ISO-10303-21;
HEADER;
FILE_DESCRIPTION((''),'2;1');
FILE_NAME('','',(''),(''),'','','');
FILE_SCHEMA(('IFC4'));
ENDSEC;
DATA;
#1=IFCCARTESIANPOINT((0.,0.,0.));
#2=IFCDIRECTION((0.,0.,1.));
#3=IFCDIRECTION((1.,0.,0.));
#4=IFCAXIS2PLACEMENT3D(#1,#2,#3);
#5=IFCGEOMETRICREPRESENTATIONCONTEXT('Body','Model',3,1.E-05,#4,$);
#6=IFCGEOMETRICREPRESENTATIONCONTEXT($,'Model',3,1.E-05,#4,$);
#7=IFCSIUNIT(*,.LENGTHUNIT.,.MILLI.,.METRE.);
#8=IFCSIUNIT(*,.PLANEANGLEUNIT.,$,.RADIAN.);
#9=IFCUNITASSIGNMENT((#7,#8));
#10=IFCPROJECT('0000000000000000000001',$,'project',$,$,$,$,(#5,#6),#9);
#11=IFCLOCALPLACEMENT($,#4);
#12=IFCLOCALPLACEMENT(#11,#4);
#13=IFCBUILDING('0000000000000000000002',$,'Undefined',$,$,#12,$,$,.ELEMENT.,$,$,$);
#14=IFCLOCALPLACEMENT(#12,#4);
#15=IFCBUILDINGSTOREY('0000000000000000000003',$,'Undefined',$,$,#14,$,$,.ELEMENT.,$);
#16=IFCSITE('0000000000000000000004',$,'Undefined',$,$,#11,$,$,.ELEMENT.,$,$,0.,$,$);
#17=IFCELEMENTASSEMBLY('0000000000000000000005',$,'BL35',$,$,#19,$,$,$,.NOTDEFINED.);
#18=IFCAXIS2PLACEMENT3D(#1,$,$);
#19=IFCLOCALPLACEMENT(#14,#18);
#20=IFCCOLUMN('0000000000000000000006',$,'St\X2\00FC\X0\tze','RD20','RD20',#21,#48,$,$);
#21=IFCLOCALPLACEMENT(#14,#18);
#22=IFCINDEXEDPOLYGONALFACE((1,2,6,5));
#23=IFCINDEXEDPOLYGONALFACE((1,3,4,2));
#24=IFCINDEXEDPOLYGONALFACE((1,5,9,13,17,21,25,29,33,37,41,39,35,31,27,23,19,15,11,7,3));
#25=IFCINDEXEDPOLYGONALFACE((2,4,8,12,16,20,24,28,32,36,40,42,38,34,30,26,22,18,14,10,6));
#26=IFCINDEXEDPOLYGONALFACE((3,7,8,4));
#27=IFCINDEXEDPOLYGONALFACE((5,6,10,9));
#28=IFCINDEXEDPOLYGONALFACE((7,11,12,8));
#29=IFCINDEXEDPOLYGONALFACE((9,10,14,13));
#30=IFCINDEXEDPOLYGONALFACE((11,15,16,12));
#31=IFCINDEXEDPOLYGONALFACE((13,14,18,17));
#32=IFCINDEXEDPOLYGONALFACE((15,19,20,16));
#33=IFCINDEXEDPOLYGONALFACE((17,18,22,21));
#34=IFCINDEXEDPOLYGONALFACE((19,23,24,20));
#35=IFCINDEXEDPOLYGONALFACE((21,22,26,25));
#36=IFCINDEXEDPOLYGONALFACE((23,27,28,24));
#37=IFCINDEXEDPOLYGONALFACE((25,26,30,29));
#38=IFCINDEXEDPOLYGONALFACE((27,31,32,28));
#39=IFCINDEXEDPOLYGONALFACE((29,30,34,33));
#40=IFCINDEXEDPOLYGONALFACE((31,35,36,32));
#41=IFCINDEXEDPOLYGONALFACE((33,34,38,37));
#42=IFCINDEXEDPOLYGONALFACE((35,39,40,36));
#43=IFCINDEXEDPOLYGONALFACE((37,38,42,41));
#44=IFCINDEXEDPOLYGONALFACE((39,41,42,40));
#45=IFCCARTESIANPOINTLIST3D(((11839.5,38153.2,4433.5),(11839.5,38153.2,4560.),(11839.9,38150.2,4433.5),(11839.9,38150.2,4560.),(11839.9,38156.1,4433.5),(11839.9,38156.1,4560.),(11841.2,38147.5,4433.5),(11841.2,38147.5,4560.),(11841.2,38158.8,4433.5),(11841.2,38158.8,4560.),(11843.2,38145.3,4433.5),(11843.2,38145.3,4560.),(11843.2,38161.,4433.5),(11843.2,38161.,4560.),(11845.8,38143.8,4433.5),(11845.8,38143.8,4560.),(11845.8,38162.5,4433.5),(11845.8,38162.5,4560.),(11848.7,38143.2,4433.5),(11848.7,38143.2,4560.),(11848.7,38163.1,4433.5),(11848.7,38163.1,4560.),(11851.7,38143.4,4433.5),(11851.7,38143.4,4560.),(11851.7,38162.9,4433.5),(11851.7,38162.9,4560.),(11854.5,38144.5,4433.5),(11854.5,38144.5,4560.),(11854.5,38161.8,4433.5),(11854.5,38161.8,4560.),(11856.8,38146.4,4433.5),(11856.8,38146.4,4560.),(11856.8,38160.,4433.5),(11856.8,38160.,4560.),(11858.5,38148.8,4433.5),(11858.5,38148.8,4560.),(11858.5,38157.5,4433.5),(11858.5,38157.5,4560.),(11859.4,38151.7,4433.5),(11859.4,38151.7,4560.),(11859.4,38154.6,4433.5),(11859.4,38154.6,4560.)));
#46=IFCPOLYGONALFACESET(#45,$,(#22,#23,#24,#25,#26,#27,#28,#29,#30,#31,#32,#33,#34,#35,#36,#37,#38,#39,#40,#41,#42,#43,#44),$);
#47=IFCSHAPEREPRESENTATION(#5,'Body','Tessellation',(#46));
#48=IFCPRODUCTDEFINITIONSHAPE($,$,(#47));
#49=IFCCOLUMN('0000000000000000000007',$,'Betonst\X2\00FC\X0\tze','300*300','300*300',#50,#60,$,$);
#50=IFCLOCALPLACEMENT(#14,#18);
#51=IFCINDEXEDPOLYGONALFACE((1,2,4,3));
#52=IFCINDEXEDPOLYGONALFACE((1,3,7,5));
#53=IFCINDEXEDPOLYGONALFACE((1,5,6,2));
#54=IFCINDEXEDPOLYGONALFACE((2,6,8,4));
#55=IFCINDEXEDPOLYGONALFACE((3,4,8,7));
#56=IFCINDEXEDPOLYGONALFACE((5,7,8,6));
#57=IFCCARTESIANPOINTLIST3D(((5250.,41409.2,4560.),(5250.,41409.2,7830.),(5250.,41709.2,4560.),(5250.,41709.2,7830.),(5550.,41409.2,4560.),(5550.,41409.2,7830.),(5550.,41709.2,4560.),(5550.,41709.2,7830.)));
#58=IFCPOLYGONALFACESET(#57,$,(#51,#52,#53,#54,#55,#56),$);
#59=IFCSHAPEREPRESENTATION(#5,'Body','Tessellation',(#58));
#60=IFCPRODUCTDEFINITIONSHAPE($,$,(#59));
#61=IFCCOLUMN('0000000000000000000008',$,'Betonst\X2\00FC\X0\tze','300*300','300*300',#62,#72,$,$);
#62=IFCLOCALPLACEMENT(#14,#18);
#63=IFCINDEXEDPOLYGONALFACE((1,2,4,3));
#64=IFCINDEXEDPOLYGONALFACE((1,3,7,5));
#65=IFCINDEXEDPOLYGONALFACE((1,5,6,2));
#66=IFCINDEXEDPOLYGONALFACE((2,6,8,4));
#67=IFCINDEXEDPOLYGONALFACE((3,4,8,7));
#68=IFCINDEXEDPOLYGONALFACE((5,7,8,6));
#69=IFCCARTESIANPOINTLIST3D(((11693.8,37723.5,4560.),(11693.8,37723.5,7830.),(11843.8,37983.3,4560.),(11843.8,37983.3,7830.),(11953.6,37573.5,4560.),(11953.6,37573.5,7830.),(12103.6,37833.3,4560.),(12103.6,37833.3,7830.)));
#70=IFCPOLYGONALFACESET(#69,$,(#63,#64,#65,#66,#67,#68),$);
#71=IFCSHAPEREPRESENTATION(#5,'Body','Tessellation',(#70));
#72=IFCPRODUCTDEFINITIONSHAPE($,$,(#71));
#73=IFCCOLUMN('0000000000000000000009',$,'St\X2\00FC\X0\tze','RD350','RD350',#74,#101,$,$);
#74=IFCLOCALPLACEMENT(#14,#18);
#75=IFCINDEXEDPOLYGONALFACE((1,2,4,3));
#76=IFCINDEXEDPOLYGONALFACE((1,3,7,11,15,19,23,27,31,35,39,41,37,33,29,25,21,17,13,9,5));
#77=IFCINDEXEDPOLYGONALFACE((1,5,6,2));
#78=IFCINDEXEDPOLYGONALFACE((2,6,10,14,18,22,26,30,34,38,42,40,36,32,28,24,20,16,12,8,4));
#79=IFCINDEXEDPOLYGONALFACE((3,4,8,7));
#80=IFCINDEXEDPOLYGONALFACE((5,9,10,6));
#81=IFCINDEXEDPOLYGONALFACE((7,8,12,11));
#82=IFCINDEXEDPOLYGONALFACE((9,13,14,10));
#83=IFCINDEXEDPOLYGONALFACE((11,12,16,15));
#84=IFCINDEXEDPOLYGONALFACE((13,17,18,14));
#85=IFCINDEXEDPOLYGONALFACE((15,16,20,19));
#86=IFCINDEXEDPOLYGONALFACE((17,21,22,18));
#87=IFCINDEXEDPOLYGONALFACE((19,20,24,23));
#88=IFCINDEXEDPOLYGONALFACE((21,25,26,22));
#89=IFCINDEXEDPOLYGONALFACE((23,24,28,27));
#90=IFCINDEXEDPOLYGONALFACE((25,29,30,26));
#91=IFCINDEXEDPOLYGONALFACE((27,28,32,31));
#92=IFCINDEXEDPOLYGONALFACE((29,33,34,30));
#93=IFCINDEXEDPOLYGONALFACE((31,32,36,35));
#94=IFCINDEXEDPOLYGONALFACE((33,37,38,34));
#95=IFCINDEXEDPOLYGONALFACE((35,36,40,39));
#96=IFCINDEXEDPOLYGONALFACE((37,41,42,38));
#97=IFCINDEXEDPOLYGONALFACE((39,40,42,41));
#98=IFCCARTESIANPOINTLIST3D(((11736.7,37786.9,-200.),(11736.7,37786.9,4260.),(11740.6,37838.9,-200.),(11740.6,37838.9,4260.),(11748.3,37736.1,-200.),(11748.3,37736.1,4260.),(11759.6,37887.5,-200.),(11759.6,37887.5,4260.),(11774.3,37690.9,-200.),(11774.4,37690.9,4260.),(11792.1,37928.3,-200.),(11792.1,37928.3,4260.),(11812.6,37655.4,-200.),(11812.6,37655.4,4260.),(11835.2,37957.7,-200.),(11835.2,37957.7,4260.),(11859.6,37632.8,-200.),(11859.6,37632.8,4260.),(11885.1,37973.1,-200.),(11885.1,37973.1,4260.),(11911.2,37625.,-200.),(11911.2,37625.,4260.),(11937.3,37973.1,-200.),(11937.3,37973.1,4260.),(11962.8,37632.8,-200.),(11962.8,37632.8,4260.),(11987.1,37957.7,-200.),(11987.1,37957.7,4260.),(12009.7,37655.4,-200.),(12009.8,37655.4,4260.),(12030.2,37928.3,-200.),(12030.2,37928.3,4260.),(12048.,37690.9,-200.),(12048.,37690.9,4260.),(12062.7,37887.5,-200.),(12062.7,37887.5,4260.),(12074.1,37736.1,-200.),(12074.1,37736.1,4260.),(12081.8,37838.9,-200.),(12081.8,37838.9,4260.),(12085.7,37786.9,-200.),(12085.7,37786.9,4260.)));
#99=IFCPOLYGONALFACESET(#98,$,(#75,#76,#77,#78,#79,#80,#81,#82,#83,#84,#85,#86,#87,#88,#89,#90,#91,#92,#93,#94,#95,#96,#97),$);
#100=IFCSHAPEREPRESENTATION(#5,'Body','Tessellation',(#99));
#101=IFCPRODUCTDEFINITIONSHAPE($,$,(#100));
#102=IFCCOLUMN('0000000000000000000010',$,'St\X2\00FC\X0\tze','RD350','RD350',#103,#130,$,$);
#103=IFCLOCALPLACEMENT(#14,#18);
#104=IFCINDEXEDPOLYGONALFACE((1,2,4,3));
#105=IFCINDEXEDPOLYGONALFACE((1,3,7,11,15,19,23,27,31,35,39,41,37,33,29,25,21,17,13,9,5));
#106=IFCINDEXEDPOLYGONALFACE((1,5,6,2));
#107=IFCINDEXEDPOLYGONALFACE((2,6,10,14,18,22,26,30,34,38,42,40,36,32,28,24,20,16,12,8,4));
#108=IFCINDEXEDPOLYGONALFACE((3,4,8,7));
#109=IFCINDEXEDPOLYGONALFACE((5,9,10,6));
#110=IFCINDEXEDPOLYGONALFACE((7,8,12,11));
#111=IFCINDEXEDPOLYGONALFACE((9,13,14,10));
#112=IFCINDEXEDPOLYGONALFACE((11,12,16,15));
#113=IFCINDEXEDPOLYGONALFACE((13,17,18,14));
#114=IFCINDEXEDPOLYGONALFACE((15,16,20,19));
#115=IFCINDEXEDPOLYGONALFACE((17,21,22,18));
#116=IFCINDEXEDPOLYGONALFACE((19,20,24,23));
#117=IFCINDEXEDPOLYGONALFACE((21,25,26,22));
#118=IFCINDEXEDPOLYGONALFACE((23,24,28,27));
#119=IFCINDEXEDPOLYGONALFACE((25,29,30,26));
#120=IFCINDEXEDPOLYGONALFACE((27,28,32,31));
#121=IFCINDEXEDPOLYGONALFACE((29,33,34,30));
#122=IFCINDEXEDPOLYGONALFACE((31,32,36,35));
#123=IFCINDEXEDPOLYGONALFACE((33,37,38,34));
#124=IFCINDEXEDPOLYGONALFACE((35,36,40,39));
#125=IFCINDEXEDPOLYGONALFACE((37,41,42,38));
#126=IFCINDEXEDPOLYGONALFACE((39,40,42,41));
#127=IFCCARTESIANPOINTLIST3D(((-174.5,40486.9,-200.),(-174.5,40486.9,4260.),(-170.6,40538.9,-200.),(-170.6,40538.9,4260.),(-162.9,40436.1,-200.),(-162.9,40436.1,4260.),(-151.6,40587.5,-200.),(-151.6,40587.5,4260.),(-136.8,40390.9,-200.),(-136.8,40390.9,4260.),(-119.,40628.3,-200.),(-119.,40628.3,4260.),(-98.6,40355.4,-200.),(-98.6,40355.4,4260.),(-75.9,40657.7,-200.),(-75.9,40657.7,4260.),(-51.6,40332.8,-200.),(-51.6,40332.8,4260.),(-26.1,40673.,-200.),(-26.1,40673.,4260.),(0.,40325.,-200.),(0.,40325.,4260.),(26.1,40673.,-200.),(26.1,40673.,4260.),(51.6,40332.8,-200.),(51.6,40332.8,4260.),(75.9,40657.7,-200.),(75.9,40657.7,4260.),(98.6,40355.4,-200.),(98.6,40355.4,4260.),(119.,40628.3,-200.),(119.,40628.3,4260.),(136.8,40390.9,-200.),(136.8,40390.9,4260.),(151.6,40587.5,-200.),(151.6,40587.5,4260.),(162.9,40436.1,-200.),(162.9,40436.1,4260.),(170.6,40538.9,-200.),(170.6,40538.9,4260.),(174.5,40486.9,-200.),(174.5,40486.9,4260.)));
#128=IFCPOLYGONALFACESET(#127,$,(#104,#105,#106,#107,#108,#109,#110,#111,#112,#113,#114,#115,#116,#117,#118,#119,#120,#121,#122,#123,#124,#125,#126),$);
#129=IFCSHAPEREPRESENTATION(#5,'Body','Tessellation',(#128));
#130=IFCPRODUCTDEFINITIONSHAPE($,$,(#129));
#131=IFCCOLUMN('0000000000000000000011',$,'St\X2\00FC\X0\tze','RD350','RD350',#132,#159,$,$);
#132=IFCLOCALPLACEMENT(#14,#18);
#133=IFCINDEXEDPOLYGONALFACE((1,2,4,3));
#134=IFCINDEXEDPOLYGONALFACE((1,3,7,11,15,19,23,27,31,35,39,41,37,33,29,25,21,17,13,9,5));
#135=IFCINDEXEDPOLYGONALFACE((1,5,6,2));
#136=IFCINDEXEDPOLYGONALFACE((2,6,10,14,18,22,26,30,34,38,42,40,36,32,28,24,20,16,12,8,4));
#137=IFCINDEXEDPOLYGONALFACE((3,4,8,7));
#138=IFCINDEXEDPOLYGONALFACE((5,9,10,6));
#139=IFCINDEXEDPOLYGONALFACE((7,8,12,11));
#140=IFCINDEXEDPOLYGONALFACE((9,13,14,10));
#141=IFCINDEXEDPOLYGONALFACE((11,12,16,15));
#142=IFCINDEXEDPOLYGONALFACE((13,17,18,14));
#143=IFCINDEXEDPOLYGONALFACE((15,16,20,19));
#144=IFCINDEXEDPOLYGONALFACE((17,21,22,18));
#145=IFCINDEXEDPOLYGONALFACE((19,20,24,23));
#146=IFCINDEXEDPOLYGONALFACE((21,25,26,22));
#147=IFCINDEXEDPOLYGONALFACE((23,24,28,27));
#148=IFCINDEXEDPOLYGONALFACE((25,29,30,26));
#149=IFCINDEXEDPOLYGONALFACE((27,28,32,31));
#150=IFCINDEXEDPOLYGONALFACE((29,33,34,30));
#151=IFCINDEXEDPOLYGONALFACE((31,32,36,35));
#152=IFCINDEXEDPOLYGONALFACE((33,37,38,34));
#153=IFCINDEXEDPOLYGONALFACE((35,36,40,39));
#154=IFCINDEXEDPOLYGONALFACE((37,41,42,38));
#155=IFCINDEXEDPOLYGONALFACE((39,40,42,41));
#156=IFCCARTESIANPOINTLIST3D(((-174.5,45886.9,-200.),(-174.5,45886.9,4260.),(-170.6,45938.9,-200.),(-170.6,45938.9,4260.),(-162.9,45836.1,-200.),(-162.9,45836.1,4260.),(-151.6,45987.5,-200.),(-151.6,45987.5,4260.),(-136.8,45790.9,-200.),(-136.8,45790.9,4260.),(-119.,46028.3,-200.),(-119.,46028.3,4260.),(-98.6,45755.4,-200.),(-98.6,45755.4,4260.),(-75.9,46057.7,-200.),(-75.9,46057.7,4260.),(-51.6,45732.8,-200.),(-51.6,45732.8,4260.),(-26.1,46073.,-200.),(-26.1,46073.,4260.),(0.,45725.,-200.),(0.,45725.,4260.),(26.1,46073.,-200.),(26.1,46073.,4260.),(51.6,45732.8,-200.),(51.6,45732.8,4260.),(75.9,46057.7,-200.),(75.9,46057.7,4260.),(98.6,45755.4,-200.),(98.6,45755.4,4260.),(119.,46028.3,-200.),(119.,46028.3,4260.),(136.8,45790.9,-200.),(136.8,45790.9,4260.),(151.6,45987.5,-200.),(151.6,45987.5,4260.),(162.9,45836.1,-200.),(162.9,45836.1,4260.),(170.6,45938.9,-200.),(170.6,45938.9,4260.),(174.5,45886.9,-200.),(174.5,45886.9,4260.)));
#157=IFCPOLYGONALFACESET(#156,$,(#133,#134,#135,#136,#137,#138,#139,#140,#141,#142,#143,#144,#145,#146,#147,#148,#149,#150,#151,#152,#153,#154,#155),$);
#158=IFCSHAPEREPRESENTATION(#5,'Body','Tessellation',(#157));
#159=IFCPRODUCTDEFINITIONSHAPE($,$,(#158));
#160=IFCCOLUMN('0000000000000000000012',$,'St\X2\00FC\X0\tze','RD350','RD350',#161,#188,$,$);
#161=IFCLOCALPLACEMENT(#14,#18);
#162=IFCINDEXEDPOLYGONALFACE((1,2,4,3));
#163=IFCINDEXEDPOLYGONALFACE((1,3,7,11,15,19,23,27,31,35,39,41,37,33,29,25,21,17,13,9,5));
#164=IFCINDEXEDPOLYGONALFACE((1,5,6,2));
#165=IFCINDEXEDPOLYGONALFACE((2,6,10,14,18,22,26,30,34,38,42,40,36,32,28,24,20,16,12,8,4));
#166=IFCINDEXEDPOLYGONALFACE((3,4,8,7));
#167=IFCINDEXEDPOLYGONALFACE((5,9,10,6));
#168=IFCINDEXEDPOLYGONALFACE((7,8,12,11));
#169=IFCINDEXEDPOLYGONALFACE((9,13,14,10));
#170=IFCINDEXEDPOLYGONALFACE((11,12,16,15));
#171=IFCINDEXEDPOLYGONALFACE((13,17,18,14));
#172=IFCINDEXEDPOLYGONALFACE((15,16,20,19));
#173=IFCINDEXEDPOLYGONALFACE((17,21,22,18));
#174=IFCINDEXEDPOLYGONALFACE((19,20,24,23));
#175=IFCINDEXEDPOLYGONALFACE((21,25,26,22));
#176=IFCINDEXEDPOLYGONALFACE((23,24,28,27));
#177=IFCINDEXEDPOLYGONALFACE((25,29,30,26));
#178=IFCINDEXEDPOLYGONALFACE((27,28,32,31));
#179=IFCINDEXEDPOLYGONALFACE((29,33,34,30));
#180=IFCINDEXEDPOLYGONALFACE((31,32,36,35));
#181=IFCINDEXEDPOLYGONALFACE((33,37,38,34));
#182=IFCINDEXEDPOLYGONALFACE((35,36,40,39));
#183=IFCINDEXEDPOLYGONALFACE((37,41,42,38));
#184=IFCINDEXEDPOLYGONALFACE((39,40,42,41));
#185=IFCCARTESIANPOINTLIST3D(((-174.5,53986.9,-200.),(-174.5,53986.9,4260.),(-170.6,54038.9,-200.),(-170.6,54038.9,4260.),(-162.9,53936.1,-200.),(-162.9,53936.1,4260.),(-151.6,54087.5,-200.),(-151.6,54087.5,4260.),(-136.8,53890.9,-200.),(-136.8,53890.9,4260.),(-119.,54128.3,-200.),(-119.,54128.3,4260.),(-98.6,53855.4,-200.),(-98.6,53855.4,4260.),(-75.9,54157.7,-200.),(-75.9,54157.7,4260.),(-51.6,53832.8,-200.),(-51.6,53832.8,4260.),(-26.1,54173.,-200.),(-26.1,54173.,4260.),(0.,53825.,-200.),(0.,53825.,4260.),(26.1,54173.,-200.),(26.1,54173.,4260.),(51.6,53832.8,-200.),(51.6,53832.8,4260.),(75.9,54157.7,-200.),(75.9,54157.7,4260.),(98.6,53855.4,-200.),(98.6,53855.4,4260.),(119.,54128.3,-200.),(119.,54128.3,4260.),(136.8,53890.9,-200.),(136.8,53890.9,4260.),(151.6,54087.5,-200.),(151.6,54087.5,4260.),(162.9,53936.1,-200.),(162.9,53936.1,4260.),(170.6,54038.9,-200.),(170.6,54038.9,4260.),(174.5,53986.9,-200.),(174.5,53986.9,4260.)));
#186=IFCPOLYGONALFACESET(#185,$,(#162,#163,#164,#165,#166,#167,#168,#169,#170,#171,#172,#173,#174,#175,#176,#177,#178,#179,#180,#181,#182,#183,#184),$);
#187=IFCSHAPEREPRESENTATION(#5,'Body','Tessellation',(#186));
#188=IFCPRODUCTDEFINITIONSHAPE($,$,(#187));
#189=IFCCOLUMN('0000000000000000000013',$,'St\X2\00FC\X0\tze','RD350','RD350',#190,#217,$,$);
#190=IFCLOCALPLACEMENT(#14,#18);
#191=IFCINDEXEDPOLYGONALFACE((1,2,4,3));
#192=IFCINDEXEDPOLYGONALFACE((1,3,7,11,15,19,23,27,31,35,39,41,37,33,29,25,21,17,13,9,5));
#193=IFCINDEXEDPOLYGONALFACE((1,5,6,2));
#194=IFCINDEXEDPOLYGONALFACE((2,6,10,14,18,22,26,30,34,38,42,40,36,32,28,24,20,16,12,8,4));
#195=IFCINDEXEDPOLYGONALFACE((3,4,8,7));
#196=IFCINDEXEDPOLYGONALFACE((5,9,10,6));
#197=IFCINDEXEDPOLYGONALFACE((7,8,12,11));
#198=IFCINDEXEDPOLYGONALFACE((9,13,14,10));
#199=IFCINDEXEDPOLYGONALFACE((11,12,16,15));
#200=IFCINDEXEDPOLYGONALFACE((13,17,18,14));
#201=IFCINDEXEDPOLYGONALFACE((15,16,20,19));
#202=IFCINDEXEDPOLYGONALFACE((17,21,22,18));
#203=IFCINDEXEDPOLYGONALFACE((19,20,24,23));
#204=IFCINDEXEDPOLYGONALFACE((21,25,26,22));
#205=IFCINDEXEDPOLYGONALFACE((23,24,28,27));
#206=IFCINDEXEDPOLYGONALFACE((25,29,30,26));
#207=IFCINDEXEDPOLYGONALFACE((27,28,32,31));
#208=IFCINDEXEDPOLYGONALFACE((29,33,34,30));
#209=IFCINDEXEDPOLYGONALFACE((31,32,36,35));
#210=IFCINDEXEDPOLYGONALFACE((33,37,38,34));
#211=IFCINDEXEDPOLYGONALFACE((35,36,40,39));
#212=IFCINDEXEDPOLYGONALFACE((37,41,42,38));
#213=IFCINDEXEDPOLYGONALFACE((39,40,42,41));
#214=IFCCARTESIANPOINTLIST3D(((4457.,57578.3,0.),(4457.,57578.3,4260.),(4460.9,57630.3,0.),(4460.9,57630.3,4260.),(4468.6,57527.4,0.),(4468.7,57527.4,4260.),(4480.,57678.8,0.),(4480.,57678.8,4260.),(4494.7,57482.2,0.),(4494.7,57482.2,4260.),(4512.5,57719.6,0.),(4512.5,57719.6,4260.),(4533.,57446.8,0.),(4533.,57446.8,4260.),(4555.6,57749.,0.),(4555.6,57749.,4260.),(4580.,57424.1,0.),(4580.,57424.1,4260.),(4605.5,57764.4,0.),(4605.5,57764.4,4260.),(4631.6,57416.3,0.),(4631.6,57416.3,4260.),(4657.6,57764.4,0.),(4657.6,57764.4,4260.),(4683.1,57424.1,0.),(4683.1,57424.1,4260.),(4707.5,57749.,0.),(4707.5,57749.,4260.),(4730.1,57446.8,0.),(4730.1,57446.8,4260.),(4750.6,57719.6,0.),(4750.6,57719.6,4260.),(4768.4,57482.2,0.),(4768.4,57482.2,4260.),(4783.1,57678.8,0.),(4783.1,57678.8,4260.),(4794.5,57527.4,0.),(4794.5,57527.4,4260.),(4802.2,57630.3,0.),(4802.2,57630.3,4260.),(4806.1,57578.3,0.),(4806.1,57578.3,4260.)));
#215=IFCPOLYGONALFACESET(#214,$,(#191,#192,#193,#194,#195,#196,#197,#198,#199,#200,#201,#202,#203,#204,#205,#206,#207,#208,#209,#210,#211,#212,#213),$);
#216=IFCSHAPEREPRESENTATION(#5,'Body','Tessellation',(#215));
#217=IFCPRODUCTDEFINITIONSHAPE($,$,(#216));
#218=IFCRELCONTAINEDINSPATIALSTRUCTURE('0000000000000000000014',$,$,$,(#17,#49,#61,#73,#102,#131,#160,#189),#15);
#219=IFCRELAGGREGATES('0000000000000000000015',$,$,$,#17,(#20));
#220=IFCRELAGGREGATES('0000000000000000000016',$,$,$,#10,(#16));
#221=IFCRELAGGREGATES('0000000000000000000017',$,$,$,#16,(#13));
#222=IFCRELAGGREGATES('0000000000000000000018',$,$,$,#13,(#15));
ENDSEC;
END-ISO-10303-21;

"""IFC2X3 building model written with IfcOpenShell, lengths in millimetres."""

from ifc_helpers import new_model, si_unit, frame, origin_with_axes, origin_2d_with_axis, place, context, project, spatial, rectangle, circle, extrude, element, aggregate, save


model = new_model("IFC2X3")

# Units and contexts
model_context_1 = context("Model", 3, precision=1e-05, world=origin_with_axes(), identifier="Body")
model_context_2 = context("Model", 3, precision=1e-05, world=origin_with_axes())
ifc_project = project(units=[si_unit("LENGTHUNIT", "METRE", prefix="MILLI"), si_unit("PLANEANGLEUNIT", "RADIAN")], contexts=[model_context_1, model_context_2])

# Site, building, storey
site_placement = place(None, origin_with_axes())
site = spatial("IfcSite", under=ifc_project, at=site_placement, Name="Undefined", CompositionType="ELEMENT", RefElevation=0.0)
building_placement = place(site_placement, origin_with_axes())
building = spatial("IfcBuilding", under=site, at=building_placement, Name="Undefined", CompositionType="ELEMENT")
storey_placement = place(building_placement, origin_with_axes())
storey = spatial("IfcBuildingStorey", under=building, at=storey_placement, Name="Undefined", CompositionType="ELEMENT")

# Element assembly, column
assembly_1 = element("IfcElementAssembly", 1, inside=storey, Name="BL35", PredefinedType="NOTDEFINED")
column_1_placement = place(storey_placement, frame((11849.5, 38153.2, 4433.5), z_axis=(0.0, 0.0, 1.0), x_axis=(1.0, 0.0, 0.0)))
column_1 = element("IfcColumn", 2, at=column_1_placement, Name="Stütze", Description="RD20", ObjectType="RD20", context=model_context_1, shape_type="SweptSolid", body=[
    extrude(circle(Radius=10.0, at=origin_2d_with_axis()), frame((0.0, 0.0, 126.5), z_axis=(0.0, 0.0, -1.0), x_axis=(0.5, 0.866025, 0.0)), (0.0, 0.0, 1.0), 126.5),
])
aggregate(assembly_1, [column_1])

# Columns
column_2_placement = place(storey_placement, frame((5400.0, 41559.2, 4560.0), z_axis=(0.0, 0.0, 1.0), x_axis=(1.0, 0.0, 0.0)))
element("IfcColumn", 3, at=column_2_placement, inside=storey, Name="Betonstütze", Description="300*300", ObjectType="300*300", context=model_context_1, shape_type="SweptSolid", body=[
    extrude(rectangle(XDim=300.0, YDim=300.0, at=origin_2d_with_axis()), frame((0.0, 0.0, 3270.0), z_axis=(0.0, 0.0, -1.0), x_axis=(1.0, 0.0, 0.0)), (0.0, 0.0, 1.0), 3270.0),
])
column_3_placement = place(storey_placement, frame((11898.7, 37778.4, 4560.0), z_axis=(0.0, 0.0, 1.0), x_axis=(1.0, 0.0, 0.0)))
element("IfcColumn", 4, at=column_3_placement, inside=storey, Name="Betonstütze", Description="300*300", ObjectType="300*300", context=model_context_1, shape_type="SweptSolid", body=[
    extrude(rectangle(XDim=300.0, YDim=300.0, at=origin_2d_with_axis()), frame((0.0, 0.0, 3270.0), z_axis=(0.0, 0.0, -1.0), x_axis=(0.866025, -0.5, 0.0)), (0.0, 0.0, 1.0), 3270.0),
])
for number, where, z_axis, x_axis, name in (
    (5, (11911.2, 37800.0, -200.0), (0.0, 0.0, 1.0), (1.0, 0.0, 0.0), "Stütze"),
    (6, (0.0, 40500.0, -200.0), (0.0, 0.0, 1.0), (1.0, 0.0, 0.0), "Stütze"),
    (7, (0.0, 45900.0, -200.0), (0.0, 0.0, 1.0), (1.0, 0.0, 0.0), "Stütze"),
    (8, (0.0, 54000.0, -200.0), (0.0, 0.0, 1.0), (1.0, 0.0, 0.0), "Stütze"),
):
    element("IfcColumn", number, at=place(storey_placement, frame(where, z_axis=z_axis, x_axis=x_axis)), inside=storey, Name=name, Description="RD350", ObjectType="RD350", context=model_context_1, shape_type="SweptSolid", body=[
        extrude(circle(Radius=175.0, at=origin_2d_with_axis()), frame((0.0, 0.0, 4460.0), z_axis=(0.0, 0.0, -1.0), x_axis=(-0.866025, 0.500001, 0.0)), (0.0, 0.0, 1.0), 4460.0),
    ])
column_4_placement = place(storey_placement, frame((4631.6, 57591.3, 0.0), z_axis=(0.0, 0.0, 1.0), x_axis=(1.0, 0.0, 0.0)))
element("IfcColumn", 9, at=column_4_placement, inside=storey, Name="Stütze", Description="RD350", ObjectType="RD350", context=model_context_1, shape_type="SweptSolid", body=[
    extrude(circle(Radius=175.0, at=origin_2d_with_axis()), frame((0.0, 0.0, 4260.0), z_axis=(0.0, 0.0, -1.0), x_axis=(-0.866025, 0.500001, 0.0)), (0.0, 0.0, 1.0), 4260.0),
])

save(model, "model.ifc")
